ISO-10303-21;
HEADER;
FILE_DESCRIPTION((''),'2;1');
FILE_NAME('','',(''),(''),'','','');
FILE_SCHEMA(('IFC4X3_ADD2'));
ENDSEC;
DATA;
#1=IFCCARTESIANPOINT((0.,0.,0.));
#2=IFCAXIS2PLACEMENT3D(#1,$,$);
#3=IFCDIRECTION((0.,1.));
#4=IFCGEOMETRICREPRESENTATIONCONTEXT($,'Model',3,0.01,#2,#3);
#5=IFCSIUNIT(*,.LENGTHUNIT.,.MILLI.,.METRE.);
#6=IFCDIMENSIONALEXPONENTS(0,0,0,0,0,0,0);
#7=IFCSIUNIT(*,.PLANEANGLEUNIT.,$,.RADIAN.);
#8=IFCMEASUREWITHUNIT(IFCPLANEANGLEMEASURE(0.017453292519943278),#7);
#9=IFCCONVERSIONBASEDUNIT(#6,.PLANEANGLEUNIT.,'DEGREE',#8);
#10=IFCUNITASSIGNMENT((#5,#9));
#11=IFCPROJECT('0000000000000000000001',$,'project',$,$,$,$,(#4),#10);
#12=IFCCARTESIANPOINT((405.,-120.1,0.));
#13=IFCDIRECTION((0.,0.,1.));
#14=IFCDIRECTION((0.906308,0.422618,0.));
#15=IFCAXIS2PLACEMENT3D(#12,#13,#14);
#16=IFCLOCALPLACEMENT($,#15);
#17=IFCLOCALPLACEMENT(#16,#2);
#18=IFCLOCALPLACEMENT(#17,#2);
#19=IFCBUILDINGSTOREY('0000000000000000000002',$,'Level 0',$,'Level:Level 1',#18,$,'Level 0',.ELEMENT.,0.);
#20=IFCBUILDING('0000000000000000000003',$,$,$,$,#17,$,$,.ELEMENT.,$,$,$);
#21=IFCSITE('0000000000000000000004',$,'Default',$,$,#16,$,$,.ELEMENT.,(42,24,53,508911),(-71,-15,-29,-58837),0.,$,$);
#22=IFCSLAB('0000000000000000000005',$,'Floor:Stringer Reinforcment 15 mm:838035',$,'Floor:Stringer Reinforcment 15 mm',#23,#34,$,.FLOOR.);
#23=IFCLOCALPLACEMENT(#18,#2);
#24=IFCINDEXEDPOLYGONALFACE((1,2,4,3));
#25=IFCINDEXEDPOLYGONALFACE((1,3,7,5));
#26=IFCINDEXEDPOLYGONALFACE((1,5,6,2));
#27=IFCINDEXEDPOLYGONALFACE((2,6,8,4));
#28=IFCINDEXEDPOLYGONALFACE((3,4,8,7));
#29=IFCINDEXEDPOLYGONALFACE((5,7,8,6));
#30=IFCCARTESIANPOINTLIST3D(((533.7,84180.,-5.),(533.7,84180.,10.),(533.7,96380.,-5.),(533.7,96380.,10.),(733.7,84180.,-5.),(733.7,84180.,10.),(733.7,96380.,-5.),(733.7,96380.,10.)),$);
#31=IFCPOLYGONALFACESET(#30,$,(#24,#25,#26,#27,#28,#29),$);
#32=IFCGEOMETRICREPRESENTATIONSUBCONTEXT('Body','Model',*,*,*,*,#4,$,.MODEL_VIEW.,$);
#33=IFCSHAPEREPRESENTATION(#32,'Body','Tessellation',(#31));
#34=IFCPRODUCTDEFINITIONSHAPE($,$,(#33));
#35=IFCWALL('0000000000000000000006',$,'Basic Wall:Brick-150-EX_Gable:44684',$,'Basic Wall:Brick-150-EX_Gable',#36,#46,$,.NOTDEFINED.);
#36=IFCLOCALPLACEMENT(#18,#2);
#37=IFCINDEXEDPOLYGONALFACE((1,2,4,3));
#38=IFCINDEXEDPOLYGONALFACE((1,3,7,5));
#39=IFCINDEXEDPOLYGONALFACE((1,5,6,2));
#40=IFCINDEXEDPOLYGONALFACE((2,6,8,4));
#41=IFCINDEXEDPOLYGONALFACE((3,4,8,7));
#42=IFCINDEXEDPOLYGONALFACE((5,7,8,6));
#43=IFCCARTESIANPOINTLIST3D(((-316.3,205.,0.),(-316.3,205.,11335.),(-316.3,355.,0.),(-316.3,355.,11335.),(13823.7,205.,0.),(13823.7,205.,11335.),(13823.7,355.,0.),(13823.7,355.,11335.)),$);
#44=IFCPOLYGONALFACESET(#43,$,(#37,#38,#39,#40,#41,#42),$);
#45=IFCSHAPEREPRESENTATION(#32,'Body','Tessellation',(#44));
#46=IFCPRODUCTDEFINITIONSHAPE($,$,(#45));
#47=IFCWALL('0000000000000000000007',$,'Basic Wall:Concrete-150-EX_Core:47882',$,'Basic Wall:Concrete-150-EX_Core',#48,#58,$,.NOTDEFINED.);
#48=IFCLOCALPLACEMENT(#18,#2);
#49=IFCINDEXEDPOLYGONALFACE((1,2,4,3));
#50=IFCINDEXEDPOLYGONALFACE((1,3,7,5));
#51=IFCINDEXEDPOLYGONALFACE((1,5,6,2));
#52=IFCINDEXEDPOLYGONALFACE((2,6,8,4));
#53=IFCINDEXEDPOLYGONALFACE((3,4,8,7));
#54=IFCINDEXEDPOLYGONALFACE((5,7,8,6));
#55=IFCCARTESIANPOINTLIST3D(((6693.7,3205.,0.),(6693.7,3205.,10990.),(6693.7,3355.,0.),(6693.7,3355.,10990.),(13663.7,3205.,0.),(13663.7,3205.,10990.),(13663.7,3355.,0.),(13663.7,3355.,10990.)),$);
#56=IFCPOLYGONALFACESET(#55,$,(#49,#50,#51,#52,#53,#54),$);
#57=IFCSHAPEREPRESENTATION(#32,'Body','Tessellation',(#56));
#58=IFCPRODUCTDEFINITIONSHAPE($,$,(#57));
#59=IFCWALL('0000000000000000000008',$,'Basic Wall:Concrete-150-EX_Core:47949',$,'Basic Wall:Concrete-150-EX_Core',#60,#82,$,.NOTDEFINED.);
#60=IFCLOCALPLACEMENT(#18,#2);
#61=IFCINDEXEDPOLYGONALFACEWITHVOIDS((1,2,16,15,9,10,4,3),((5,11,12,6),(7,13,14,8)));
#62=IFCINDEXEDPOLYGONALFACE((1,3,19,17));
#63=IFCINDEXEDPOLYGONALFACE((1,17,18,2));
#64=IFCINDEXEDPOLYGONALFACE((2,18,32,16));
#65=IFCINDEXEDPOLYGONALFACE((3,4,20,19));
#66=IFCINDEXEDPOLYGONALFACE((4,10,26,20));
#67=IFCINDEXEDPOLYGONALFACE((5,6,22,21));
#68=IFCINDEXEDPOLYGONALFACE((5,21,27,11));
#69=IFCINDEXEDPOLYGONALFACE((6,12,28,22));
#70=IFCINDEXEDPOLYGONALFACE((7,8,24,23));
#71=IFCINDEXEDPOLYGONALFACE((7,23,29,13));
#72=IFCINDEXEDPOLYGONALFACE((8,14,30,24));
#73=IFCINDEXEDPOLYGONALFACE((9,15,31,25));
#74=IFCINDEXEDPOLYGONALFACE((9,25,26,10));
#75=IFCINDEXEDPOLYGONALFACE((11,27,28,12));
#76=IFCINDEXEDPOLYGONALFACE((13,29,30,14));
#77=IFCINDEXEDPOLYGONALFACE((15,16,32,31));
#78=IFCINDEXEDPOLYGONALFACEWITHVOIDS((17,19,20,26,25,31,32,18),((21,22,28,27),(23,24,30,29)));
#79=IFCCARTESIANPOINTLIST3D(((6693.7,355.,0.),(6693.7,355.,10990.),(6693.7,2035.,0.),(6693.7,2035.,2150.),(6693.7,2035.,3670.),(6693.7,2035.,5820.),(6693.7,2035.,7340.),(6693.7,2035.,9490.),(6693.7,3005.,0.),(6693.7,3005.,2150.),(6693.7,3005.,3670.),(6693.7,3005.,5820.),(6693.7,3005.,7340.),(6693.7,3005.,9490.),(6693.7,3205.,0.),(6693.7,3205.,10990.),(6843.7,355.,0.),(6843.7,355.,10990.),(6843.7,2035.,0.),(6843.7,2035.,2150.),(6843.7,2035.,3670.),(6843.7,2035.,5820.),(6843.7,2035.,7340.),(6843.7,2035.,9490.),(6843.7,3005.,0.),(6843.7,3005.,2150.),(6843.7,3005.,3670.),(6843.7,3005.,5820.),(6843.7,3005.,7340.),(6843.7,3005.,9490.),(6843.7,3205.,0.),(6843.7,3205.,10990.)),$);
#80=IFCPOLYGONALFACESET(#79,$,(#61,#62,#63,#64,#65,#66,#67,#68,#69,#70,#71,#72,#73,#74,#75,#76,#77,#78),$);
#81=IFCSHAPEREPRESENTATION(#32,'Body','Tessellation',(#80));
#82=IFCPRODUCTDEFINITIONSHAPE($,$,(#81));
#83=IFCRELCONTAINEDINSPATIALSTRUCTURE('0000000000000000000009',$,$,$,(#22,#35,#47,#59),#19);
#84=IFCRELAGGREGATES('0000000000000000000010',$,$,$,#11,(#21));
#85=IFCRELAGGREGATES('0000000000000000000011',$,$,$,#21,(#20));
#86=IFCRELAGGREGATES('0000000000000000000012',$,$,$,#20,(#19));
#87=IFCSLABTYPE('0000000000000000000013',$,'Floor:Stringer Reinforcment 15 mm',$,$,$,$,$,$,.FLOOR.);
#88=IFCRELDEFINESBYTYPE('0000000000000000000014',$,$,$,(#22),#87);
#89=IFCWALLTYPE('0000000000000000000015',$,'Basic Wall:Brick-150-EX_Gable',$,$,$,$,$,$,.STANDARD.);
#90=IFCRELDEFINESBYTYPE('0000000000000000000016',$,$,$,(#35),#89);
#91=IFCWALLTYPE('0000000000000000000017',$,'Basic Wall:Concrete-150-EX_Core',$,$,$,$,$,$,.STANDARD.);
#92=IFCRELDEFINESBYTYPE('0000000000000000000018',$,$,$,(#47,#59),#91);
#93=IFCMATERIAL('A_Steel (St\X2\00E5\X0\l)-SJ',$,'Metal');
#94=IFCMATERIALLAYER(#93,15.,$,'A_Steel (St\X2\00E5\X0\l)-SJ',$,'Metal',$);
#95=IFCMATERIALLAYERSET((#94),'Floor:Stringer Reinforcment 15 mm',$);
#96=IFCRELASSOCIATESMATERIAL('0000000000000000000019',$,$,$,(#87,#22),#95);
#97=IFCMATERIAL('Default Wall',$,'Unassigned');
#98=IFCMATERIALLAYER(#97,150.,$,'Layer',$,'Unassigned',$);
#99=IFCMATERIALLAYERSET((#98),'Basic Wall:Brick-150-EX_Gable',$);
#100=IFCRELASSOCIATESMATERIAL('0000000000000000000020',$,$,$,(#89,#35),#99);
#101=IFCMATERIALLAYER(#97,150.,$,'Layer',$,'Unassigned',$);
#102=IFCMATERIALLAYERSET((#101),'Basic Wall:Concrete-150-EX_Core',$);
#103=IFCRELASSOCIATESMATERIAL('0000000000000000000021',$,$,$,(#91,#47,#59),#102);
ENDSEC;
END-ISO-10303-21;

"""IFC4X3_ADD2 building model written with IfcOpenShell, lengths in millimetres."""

from ifc_helpers import new_model, entity, si_unit, converted_unit, direction, frame, frame_2d, origin, place, context, subcontext, project, spatial, rectangle, extrude, material, layer, layer_set, layer_usage, type_object, element, save


model = new_model("IFC4X3_ADD2")

# Units and contexts
model_context = context("Model", 3, precision=0.01, world=origin(), true_north=direction((0.0, 1.0)))
body_context = subcontext(model_context, "Body", "Model", "MODEL_VIEW")
ifc_project = project(units=[si_unit("LENGTHUNIT", "METRE", prefix="MILLI"), converted_unit("PLANEANGLEUNIT", "DEGREE", entity("IfcPlaneAngleMeasure", 0.017453292519943278), si_unit("PLANEANGLEUNIT", "RADIAN"), dimensions=[0, 0, 0, 0, 0, 0, 0])], contexts=[model_context])

# Site, building, storey
site_placement = place(None, frame((405.0, -120.1, 0.0), z_axis=(0.0, 0.0, 1.0), x_axis=(0.906308, 0.422618, 0.0)))
site = spatial("IfcSite", under=ifc_project, at=site_placement, Name="Default", CompositionType="ELEMENT", RefLatitude=(42, 24, 53, 508911), RefLongitude=(-71, -15, -29, -58837), RefElevation=0.0)
building_placement = place(site_placement, origin())
building = spatial("IfcBuilding", under=site, at=building_placement, CompositionType="ELEMENT")
storey_placement = place(building_placement, origin())
storey = spatial("IfcBuildingStorey", under=building, at=storey_placement, Name="Level 0", ObjectType="Level:Level 1", LongName="Level 0", CompositionType="ELEMENT", Elevation=0.0)

# Slab
ifc_material_1 = material(Name="A_Steel (Stål)-SJ", Category="Metal")
ifc_layer_1 = layer(ifc_material_1, 15.0, Name="A_Steel (Stål)-SJ", Category="Metal")
ifc_layer_set_1 = layer_set([ifc_layer_1], Name="Floor:Stringer Reinforcment 15 mm")
ifc_layer_usage_1 = layer_usage(ifc_layer_set_1, "AXIS3", "POSITIVE", 0.0)
slab_type_1 = type_object("IfcSlabType", Name="Floor:Stringer Reinforcment 15 mm", PredefinedType="FLOOR", material=ifc_layer_set_1)
slab_1_placement = place(storey_placement, origin())
element("IfcSlab", 1, at=slab_1_placement, inside=storey, type_object=slab_type_1, material=ifc_layer_usage_1, Name="Floor:Stringer Reinforcment 15 mm:838035", ObjectType="Floor:Stringer Reinforcment 15 mm", PredefinedType="FLOOR", context=body_context, shape_type="SweptSolid", body=[
    extrude(rectangle(XDim=12200.0, YDim=200.0, at=frame_2d((0.0, 0.0), x_axis=(1.0, 0.0))), frame((633.7, 90280.0, 10.0), z_axis=(0.0, 0.0, -1.0), x_axis=(0.0, 1.0, 0.0)), (0.0, 0.0, 1.0), 15.0),
])

# Walls
ifc_material_2 = material(Name="Default Wall", Category="Unassigned")
ifc_layer_2 = layer(ifc_material_2, 150.0, Name="Layer", Category="Unassigned")
ifc_layer_set_2 = layer_set([ifc_layer_2], Name="Basic Wall:Brick-150-EX_Gable")
wall_type_1 = type_object("IfcWallType", Name="Basic Wall:Brick-150-EX_Gable", PredefinedType="STANDARD", material=ifc_layer_set_2)
wall_1_placement = place(storey_placement, frame((13823.7, 280.0, 0.0), z_axis=(0.0, 0.0, 1.0), x_axis=(-1.0, 0.0, 0.0)))
element("IfcWall", 2, at=wall_1_placement, inside=storey, type_object=wall_type_1, material=ifc_layer_set_2, Name="Basic Wall:Brick-150-EX_Gable:44684", ObjectType="Basic Wall:Brick-150-EX_Gable", PredefinedType="NOTDEFINED", context=body_context, shape_type="SweptSolid", body=[
    extrude(rectangle(XDim=14140.0, YDim=150.0, at=frame_2d((7070.0, 0.0), x_axis=(-1.0, 0.0))), origin(), (0.0, 0.0, 1.0), 11335.0),
])
ifc_layer_3 = layer(ifc_material_2, 150.0, Name="Layer", Category="Unassigned")
ifc_layer_set_3 = layer_set([ifc_layer_3], Name="Basic Wall:Concrete-150-EX_Core")
wall_type_2 = type_object("IfcWallType", Name="Basic Wall:Concrete-150-EX_Core", PredefinedType="STANDARD", material=ifc_layer_set_3)
wall_2_placement = place(storey_placement, frame((13663.7, 3280.0, 0.0), z_axis=(0.0, 0.0, 1.0), x_axis=(-1.0, 0.0, 0.0)))
element("IfcWall", 3, at=wall_2_placement, inside=storey, type_object=wall_type_2, material=ifc_layer_set_3, Name="Basic Wall:Concrete-150-EX_Core:47882", ObjectType="Basic Wall:Concrete-150-EX_Core", PredefinedType="NOTDEFINED", context=body_context, shape_type="SweptSolid", body=[
    extrude(rectangle(XDim=6970.0, YDim=150.0, at=frame_2d((3485.0, 0.0), x_axis=(-1.0, 0.0))), origin(), (0.0, 0.0, 1.0), 10990.0),
])

# Wall, openings
wall_3_placement = place(storey_placement, frame((6768.7, 3205.0, 0.0), z_axis=(0.0, 0.0, 1.0), x_axis=(0.0, -1.0, 0.0)))
wall_3 = element("IfcWall", 4, at=wall_3_placement, inside=storey, type_object=wall_type_2, material=ifc_layer_set_3, Name="Basic Wall:Concrete-150-EX_Core:47949", ObjectType="Basic Wall:Concrete-150-EX_Core", PredefinedType="NOTDEFINED", context=body_context, shape_type="SweptSolid", body=[
    extrude(rectangle(XDim=2850.0, YDim=150.0, at=frame_2d((1425.0, 0.0), x_axis=(-1.0, 0.0))), origin(), (0.0, 0.0, 1.0), 10990.0),
])
opening_1_placement = place(wall_3_placement, origin())
element("IfcOpeningElement", 5, at=opening_1_placement, cuts=wall_3, PredefinedType="OPENING", context=body_context, shape_type="SweptSolid", body=[
    extrude(rectangle(XDim=2150.0, YDim=970.0, at=frame_2d((0.0, 0.0), x_axis=(0.0, 1.0))), frame((685.0, 75.0, 4745.0), z_axis=(0.0, -1.0, 0.0), x_axis=(1.0, 0.0, 0.0)), (0.0, 0.0, 1.0), 150.0),
])
opening_2_placement = place(wall_3_placement, origin())
element("IfcOpeningElement", 6, at=opening_2_placement, cuts=wall_3, PredefinedType="OPENING", context=body_context, shape_type="SweptSolid", body=[
    extrude(rectangle(XDim=2150.0, YDim=970.0, at=frame_2d((0.0, 0.0), x_axis=(0.0, 1.0))), frame((685.0, 75.0, 8415.0), z_axis=(0.0, -1.0, 0.0), x_axis=(1.0, 0.0, 0.0)), (0.0, 0.0, 1.0), 150.0),
])
opening_3_placement = place(wall_3_placement, origin())
element("IfcOpeningElement", 7, at=opening_3_placement, cuts=wall_3, PredefinedType="OPENING", context=body_context, shape_type="SweptSolid", body=[
    extrude(rectangle(XDim=2150.0, YDim=970.0, at=frame_2d((0.0, 0.0), x_axis=(0.0, 1.0))), frame((685.0, 75.0, 1075.0), z_axis=(0.0, -1.0, 0.0), x_axis=(1.0, 0.0, 0.0)), (0.0, 0.0, 1.0), 150.0),
])

save(model, "model.ifc")
